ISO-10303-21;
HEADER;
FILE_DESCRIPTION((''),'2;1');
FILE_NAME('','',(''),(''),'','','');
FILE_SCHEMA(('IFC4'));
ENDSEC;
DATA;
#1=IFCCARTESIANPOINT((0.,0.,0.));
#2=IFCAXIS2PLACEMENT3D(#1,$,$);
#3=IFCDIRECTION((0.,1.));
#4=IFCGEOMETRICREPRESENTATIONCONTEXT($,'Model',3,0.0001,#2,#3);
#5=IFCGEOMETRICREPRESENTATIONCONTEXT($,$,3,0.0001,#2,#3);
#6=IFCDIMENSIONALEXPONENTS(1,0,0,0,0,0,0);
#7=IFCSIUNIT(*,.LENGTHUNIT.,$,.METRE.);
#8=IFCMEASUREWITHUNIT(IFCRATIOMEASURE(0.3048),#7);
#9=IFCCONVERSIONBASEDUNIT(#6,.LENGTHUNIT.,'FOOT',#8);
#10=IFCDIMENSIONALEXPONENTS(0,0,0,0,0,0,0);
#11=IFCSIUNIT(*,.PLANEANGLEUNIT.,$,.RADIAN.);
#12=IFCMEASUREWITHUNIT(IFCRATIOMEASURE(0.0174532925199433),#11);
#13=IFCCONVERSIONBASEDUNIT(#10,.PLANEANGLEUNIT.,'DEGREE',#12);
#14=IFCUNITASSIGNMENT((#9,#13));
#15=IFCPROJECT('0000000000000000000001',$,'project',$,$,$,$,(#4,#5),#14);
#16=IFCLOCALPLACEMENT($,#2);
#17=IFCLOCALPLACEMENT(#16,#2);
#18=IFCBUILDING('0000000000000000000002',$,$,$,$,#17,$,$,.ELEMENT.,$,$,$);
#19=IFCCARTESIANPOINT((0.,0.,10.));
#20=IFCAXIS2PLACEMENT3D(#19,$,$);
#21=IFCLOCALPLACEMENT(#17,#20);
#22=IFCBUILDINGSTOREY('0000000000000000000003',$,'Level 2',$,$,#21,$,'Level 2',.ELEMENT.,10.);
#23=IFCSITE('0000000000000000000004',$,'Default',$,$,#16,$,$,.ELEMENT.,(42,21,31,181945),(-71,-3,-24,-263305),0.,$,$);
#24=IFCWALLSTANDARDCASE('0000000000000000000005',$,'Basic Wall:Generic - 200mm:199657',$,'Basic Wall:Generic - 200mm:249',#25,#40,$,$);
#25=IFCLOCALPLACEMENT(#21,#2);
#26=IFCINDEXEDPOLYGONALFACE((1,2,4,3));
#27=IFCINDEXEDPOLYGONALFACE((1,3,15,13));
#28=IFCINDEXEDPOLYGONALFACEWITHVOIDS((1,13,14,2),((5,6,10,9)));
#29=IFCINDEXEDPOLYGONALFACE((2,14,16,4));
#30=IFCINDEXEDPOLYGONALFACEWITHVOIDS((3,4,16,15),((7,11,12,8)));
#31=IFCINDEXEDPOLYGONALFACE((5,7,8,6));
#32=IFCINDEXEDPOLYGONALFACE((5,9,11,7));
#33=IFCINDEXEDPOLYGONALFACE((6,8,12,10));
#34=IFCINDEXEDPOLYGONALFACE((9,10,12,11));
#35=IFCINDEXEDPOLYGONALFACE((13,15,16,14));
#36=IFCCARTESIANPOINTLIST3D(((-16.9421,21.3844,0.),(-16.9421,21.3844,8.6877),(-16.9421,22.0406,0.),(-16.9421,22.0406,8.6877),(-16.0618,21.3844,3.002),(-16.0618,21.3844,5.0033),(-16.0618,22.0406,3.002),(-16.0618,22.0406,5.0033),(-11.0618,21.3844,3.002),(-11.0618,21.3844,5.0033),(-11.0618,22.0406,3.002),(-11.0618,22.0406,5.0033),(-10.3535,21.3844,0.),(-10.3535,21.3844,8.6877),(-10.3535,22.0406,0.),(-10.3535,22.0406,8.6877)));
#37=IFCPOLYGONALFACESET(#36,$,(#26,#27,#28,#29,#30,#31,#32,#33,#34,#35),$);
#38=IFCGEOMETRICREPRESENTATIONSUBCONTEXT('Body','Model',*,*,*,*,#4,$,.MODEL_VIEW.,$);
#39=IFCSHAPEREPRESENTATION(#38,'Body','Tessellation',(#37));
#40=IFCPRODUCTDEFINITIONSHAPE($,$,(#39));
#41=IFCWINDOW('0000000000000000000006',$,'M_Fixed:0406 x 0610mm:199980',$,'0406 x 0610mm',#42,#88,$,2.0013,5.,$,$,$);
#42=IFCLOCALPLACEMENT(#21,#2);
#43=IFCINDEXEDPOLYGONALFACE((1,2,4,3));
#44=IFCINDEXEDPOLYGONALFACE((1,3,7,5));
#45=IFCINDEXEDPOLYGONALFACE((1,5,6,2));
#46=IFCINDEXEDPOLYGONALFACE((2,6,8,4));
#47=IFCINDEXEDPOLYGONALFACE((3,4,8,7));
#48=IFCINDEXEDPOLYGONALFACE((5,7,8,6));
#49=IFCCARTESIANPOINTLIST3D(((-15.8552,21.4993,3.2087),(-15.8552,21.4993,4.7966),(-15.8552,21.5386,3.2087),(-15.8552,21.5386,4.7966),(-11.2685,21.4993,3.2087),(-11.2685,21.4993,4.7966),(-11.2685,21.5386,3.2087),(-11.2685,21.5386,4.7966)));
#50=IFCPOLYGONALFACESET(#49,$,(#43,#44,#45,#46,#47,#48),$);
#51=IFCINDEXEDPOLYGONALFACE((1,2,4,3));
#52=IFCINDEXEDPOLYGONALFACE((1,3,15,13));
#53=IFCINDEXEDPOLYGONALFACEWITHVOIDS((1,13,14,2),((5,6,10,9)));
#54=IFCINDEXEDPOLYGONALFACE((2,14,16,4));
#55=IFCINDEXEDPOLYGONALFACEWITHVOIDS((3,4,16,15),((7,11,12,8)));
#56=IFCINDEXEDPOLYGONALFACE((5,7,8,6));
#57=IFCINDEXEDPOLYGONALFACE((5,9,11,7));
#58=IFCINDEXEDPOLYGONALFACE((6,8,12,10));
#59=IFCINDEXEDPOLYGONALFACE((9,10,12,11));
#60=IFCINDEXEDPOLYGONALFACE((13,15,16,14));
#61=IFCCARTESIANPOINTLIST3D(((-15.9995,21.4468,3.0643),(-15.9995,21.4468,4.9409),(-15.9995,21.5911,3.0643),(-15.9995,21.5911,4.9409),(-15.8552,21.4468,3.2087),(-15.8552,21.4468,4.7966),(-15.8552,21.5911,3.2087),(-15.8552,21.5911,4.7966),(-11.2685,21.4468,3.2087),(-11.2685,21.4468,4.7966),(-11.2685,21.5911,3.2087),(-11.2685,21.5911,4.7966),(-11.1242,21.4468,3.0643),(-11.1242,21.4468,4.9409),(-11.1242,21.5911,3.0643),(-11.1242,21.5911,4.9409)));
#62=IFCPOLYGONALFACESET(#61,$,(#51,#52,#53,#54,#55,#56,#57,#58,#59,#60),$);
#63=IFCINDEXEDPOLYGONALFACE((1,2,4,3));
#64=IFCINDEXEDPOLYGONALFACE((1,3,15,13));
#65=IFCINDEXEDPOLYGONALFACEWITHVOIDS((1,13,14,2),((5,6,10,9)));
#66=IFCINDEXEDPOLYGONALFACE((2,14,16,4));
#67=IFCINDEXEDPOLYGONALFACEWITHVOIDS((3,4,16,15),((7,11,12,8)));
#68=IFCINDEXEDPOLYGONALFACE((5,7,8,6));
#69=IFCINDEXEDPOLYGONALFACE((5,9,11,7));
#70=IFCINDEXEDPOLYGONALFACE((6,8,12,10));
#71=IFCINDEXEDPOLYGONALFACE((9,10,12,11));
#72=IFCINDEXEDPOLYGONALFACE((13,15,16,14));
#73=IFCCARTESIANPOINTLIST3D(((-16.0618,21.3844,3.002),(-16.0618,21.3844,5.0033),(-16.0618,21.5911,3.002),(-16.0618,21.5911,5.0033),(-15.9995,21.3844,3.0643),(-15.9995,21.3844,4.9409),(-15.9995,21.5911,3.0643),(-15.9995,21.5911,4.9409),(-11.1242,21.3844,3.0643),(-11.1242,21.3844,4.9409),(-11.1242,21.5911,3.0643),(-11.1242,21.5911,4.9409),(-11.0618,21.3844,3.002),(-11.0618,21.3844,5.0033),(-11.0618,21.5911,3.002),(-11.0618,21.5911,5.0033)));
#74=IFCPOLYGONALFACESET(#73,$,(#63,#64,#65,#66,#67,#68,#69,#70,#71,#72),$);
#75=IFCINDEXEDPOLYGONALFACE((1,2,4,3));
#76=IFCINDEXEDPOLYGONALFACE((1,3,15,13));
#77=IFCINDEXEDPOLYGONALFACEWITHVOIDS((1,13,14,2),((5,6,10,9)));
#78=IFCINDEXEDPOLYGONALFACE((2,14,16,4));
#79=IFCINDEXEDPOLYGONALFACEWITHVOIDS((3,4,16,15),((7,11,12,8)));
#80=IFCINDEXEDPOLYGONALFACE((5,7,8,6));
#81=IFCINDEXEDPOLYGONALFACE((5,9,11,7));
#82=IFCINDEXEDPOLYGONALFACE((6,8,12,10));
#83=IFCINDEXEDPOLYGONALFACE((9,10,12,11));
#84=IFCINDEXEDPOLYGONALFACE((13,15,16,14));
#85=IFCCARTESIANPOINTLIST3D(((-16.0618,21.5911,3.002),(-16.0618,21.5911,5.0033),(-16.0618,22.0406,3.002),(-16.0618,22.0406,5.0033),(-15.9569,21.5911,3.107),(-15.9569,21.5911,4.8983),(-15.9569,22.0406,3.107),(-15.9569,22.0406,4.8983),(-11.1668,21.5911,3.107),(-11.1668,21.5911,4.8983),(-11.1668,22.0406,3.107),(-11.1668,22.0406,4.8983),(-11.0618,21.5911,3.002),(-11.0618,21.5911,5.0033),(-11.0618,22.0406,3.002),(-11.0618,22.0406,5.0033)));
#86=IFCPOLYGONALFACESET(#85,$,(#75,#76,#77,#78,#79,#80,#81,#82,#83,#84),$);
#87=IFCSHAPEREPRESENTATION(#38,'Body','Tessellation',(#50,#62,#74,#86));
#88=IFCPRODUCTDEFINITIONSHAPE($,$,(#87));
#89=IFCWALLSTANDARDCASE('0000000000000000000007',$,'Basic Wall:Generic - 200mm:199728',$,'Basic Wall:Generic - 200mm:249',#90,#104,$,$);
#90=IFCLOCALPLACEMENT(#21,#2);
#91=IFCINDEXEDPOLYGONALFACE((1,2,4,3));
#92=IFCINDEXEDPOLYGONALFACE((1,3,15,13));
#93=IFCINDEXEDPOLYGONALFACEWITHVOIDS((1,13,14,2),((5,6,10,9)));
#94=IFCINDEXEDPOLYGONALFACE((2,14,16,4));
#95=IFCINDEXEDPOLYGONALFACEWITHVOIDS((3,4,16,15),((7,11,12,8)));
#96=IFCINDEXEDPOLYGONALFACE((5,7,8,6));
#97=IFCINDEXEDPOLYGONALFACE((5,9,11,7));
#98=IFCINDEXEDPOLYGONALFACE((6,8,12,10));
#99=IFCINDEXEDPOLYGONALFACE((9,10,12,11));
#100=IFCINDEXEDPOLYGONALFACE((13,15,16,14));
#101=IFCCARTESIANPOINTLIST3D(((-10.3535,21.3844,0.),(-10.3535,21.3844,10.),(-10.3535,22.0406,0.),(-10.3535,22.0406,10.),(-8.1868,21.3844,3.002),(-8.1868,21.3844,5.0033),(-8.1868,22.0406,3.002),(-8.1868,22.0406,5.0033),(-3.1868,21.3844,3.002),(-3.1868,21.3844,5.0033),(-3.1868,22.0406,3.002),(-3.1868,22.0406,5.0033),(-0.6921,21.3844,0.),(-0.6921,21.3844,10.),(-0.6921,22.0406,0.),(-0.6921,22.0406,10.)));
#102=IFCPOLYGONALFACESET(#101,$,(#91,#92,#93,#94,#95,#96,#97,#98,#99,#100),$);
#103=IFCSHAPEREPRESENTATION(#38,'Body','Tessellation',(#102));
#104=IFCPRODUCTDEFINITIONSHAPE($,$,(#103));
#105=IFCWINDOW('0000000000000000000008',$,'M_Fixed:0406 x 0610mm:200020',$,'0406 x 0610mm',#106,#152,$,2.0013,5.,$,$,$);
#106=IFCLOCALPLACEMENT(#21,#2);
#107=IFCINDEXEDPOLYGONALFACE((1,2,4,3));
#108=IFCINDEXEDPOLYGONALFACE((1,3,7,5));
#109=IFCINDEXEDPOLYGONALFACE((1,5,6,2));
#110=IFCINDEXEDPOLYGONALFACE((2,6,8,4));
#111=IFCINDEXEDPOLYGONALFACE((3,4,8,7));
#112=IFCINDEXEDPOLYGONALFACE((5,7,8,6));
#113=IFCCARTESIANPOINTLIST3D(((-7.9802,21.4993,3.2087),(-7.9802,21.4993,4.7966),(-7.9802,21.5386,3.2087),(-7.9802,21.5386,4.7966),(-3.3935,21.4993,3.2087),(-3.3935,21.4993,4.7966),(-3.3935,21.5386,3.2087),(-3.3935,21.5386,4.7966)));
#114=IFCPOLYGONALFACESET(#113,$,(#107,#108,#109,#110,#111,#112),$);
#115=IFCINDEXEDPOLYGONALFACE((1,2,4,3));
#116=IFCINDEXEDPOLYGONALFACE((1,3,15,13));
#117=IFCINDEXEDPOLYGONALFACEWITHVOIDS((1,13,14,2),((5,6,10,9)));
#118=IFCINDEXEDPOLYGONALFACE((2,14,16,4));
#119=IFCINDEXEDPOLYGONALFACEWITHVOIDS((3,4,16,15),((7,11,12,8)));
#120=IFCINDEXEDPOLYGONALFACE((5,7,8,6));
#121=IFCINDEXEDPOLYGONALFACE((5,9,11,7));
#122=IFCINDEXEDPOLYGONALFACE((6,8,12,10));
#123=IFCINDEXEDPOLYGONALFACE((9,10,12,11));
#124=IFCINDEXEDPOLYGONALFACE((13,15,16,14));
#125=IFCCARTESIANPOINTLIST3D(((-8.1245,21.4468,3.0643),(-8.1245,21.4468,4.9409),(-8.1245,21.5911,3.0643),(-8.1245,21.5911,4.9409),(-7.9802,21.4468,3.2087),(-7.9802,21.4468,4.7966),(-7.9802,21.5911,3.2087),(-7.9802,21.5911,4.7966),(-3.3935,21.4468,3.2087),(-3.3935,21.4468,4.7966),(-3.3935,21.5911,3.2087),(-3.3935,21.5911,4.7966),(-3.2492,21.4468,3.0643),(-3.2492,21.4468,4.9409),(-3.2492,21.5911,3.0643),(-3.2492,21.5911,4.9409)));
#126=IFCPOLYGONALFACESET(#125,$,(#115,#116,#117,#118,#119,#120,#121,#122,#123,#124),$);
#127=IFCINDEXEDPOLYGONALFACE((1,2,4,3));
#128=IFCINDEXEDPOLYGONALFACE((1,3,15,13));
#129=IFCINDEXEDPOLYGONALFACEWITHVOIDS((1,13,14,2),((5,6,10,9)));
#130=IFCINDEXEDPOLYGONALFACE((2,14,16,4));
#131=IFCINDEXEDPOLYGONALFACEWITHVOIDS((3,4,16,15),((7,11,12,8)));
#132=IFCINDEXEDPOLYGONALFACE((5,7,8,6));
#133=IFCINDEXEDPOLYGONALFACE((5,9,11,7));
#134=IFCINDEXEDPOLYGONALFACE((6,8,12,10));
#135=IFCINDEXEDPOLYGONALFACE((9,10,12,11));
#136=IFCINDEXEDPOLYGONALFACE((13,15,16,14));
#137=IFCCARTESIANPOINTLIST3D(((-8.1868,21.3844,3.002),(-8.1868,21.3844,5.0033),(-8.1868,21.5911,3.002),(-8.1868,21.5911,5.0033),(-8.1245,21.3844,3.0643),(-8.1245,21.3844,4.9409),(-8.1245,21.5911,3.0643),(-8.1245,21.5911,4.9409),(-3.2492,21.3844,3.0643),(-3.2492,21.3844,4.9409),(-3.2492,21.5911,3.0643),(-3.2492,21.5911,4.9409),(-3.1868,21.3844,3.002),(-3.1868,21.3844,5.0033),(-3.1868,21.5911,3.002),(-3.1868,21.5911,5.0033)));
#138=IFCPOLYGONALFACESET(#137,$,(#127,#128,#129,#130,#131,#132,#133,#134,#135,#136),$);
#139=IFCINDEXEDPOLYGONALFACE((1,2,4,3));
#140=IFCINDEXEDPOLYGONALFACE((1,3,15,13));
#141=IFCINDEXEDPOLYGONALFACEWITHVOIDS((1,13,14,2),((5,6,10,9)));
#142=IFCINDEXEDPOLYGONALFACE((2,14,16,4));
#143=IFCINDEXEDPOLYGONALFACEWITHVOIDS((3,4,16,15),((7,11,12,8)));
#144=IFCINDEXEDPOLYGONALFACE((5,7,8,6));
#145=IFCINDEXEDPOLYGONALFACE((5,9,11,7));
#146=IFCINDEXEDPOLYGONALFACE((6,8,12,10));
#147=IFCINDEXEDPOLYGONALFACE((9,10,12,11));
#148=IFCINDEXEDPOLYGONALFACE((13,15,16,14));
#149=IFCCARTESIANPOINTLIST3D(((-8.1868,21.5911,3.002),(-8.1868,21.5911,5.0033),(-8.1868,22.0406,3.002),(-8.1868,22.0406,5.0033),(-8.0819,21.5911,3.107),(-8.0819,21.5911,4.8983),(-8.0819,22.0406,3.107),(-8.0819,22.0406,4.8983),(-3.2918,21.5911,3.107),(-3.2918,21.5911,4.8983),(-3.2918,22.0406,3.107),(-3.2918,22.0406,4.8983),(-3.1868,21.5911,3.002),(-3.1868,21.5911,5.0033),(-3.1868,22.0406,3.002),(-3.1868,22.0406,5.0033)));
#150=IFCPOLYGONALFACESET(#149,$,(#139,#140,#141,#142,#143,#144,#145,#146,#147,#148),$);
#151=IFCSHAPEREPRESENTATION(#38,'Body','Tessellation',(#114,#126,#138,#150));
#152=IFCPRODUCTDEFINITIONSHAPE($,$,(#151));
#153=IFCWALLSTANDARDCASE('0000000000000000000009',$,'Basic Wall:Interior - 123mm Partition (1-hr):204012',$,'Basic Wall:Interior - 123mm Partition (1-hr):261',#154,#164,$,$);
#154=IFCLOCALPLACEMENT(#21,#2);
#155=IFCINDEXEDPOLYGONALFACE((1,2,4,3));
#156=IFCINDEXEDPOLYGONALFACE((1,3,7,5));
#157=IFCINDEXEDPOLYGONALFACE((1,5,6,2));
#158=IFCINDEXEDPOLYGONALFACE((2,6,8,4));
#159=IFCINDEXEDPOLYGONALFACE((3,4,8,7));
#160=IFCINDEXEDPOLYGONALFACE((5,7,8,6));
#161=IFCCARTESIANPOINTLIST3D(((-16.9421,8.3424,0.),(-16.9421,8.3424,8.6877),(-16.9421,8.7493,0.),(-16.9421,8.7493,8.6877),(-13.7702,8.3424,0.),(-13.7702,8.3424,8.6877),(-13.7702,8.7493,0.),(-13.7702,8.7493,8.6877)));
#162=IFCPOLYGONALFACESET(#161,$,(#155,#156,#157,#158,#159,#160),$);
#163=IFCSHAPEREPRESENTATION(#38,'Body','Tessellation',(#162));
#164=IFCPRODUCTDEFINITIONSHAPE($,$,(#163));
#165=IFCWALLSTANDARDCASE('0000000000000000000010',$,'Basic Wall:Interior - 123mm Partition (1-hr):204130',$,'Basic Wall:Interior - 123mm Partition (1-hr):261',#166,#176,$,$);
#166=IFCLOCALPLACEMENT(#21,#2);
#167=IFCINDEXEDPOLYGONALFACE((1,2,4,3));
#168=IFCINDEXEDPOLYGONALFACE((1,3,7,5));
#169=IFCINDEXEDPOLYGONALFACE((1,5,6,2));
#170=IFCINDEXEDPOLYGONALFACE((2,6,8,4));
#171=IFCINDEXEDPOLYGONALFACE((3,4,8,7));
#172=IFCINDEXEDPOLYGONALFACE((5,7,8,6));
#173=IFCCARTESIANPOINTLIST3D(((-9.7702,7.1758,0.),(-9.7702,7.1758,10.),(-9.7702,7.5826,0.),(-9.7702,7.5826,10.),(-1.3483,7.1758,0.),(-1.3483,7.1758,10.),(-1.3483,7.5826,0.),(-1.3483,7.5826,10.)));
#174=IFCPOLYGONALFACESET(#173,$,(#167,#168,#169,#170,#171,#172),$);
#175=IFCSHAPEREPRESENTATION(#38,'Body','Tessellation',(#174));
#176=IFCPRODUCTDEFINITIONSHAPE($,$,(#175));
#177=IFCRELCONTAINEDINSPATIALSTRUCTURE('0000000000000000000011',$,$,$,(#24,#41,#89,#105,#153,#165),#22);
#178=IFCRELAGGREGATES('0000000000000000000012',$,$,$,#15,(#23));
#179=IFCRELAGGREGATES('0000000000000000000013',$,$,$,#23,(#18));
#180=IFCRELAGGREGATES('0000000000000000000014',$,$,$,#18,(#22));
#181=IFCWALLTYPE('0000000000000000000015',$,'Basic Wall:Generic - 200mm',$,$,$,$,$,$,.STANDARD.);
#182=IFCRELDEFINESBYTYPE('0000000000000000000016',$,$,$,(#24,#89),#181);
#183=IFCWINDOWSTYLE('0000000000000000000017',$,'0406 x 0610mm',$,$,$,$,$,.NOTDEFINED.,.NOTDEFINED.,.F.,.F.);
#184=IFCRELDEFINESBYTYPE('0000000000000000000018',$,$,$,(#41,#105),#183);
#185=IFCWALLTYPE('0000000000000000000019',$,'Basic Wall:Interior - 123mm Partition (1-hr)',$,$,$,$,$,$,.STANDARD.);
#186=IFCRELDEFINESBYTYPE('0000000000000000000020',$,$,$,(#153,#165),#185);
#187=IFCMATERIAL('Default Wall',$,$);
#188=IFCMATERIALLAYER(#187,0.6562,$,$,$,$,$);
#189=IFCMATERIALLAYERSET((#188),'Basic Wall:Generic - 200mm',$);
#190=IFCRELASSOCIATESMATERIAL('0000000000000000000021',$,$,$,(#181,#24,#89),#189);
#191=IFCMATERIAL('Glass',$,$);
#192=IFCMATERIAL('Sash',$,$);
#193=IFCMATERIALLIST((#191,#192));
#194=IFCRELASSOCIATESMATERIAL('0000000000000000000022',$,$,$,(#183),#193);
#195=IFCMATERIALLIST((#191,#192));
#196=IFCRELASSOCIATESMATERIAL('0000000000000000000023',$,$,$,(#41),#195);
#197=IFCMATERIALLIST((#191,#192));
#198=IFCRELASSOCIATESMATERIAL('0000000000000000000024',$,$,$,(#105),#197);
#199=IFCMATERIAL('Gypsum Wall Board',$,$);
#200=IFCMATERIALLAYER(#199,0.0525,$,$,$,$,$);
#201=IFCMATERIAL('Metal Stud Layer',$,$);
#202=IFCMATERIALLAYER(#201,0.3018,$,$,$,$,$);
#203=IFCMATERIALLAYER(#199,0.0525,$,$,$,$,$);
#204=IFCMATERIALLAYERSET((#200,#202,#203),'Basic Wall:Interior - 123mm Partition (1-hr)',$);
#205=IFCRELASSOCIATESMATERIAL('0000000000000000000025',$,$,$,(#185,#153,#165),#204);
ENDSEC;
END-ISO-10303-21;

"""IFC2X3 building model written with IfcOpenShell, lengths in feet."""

from ifc_helpers import new_model, entity, si_unit, converted_unit, direction, frame, frame_2d, origin, place, context, subcontext, project, spatial, polyline, rectangle, outline, extrude, clip, halfspace, source, transform, mapped, material, material_list, layer, layer_set, layer_usage, type_object, type_shapes, element, fill, save


model = new_model("IFC2X3")

# Units and contexts
model_context = context("Model", 3, precision=0.0001, world=origin(), true_north=direction((0.0, 1.0)))
context_of_model = context(None, 3, precision=0.0001, world=origin(), true_north=direction((0.0, 1.0)))
body_context = subcontext(model_context, "Body", "Model", "MODEL_VIEW")
ifc_project = project(units=[converted_unit("LENGTHUNIT", "FOOT", entity("IfcRatioMeasure", 0.3048), si_unit("LENGTHUNIT", "METRE"), dimensions=[1, 0, 0, 0, 0, 0, 0]), converted_unit("PLANEANGLEUNIT", "DEGREE", entity("IfcRatioMeasure", 0.0174532925199433), si_unit("PLANEANGLEUNIT", "RADIAN"), dimensions=[0, 0, 0, 0, 0, 0, 0])], contexts=[model_context, context_of_model])

# Site, building, storey
site_placement = place(None, origin())
site = spatial("IfcSite", under=ifc_project, at=site_placement, Name="Default", CompositionType="ELEMENT", RefLatitude=(42, 21, 31, 181945), RefLongitude=(-71, -3, -24, -263305), RefElevation=0.0)
building_placement = place(site_placement, origin())
building = spatial("IfcBuilding", under=site, at=building_placement, CompositionType="ELEMENT")
storey_placement = place(building_placement, frame((0.0, 0.0, 10.0)))
storey = spatial("IfcBuildingStorey", under=building, at=storey_placement, Name="Level 2", LongName="Level 2", CompositionType="ELEMENT", Elevation=10.0)

# Shared definitions
ifc_material_1 = material(Name="Default Wall")

# Shared definitions
ifc_material_2 = material(Name="Glass")
ifc_material_3 = material(Name="Sash")

# Shared definitions
ifc_layer_1 = layer(ifc_material_1, 0.6562)
ifc_layer_set_1 = layer_set([ifc_layer_1], Name="Basic Wall:Generic - 200mm")
wall_type_1 = type_object("IfcWallType", Name="Basic Wall:Generic - 200mm", PredefinedType="STANDARD", material=ifc_layer_set_1)

# Walls, openings, windows
ifc_layer_usage_1 = layer_usage(ifc_layer_set_1, "AXIS2", "NEGATIVE", 0.3281)
wall_1_placement = place(storey_placement, frame((-16.9421, 21.7125, 0.0)))
wall_1 = element("IfcWallStandardCase", 1, at=wall_1_placement, inside=storey, type_object=wall_type_1, material=ifc_layer_usage_1, Name="Basic Wall:Generic - 200mm:199657", ObjectType="Basic Wall:Generic - 200mm:249", context=body_context, shape_type="Clipping", body=[
    clip(extrude(rectangle(XDim=6.5886, YDim=0.6562, at=frame_2d((3.2943, 0.0), x_axis=(-1.0, 0.0))), origin(), (0.0, 0.0, 1.0), 8.6877), halfspace(frame((0.0, 0.0, -10.0)), True)),
])
opening_1_placement = place(wall_1_placement, frame((5.8802, 0.3281, 3.002)))
opening_1 = element("IfcOpeningElement", 2, at=opening_1_placement, cuts=wall_1, ObjectType="Opening", context=body_context, shape_type="SweptSolid", body=[
    extrude(rectangle(XDim=2.0013, YDim=5.0, at=frame_2d((1.0007, 2.5), x_axis=(1.0, 0.0))), frame((0.0, 0.0, 0.0), z_axis=(0.0, -1.0, 0.0), x_axis=(0.0, 0.0, 1.0)), (0.0, 0.0, 1.0), 0.6562),
])
ifc_material_list_1 = material_list([ifc_material_2, ifc_material_3])
ifc_material_list_2 = material_list([ifc_material_2, ifc_material_3])
window_style_1 = type_object("IfcWindowStyle", Name="0406 x 0610mm", ConstructionType="NOTDEFINED", OperationType="NOTDEFINED", ParameterTakesPrecedence=False, Sizeable=False, material=ifc_material_list_2)
shared_shape_1 = source(origin(), body_context, "Body", "SweptSolid", [
    extrude(rectangle(XDim=0.0394, YDim=4.5866, at=frame_2d((0.0, 0.0), x_axis=(1.0, 0.0))), frame((2.5, 0.5217, 0.2067), z_axis=(0.0, 0.0, 1.0), x_axis=(0.0, -1.0, 0.0)), (0.0, 0.0, 1.0), 1.5879),
    extrude(outline(polyline([(-2.4377, -0.9383), (2.4377, -0.9383), (2.4377, 0.9383), (-2.4377, 0.9383), (-2.4377, -0.9383)]), holes=[polyline([(-2.2933, -0.794), (-2.2933, 0.794), (2.2933, 0.794), (2.2933, -0.794), (-2.2933, -0.794)])]), frame((2.5, 0.4495, 1.0007), z_axis=(0.0, 1.0, 0.0), x_axis=(1.0, 0.0, 0.0)), (0.0, 0.0, 1.0), 0.1444),
    extrude(outline(polyline([(-2.5, -1.0007), (2.5, -1.0007), (2.5, 1.0007), (-2.5, 1.0007), (-2.5, -1.0007)]), holes=[polyline([(-2.4377, -0.9383), (-2.4377, 0.9383), (2.4377, 0.9383), (2.4377, -0.9383), (-2.4377, -0.9383)])]), frame((2.5, 0.4495, 1.0007), z_axis=(0.0, 1.0, 0.0), x_axis=(1.0, 0.0, 0.0)), (0.0, 0.0, 1.0), 0.2067),
    extrude(outline(polyline([(-2.5, -1.0007), (2.5, -1.0007), (2.5, 1.0007), (-2.5, 1.0007), (-2.5, -1.0007)]), holes=[polyline([(-2.395, -0.8957), (-2.395, 0.8957), (2.395, 0.8957), (2.395, -0.8957), (-2.395, -0.8957)])]), frame((2.5, 0.0, 1.0007), z_axis=(0.0, 1.0, 0.0), x_axis=(1.0, 0.0, 0.0)), (0.0, 0.0, 1.0), 0.4495),
])
type_shapes(window_style_1, [shared_shape_1])
window_1_placement = place(opening_1_placement, frame((0.0, 0.0, 0.0), z_axis=(0.0, 0.0, 1.0), x_axis=(-1.0, 0.0, 0.0)))
window_1 = element("IfcWindow", 3, at=window_1_placement, inside=storey, type_object=window_style_1, material=ifc_material_list_1, Name="M_Fixed:0406 x 0610mm:199980", ObjectType="0406 x 0610mm", OverallHeight=2.0013, OverallWidth=5.0, context=body_context, shape_type="MappedRepresentation", body=[
    mapped(shared_shape_1, transform((0.0, 0.0, 0.0), scale=1.0)),
])
fill(opening_1, window_1)
ifc_layer_usage_2 = layer_usage(ifc_layer_set_1, "AXIS2", "NEGATIVE", 0.3281)
wall_2_placement = place(storey_placement, frame((-10.6816, 21.7125, 0.0)))
wall_2 = element("IfcWallStandardCase", 4, at=wall_2_placement, inside=storey, type_object=wall_type_1, material=ifc_layer_usage_2, Name="Basic Wall:Generic - 200mm:199728", ObjectType="Basic Wall:Generic - 200mm:249", context=body_context, shape_type="Clipping", body=[
    clip(extrude(rectangle(XDim=9.6614, YDim=0.6562, at=frame_2d((5.1588, 0.0), x_axis=(-1.0, 0.0))), origin(), (0.0, 0.0, 1.0), 10.0), halfspace(frame((0.0, 0.0, -10.0)), True)),
])
opening_2_placement = place(wall_2_placement, frame((7.4948, 0.3281, 3.002)))
opening_2 = element("IfcOpeningElement", 5, at=opening_2_placement, cuts=wall_2, ObjectType="Opening", context=body_context, shape_type="SweptSolid", body=[
    extrude(rectangle(XDim=2.0013, YDim=5.0, at=frame_2d((1.0007, 2.5), x_axis=(1.0, 0.0))), frame((0.0, 0.0, 0.0), z_axis=(0.0, -1.0, 0.0), x_axis=(0.0, 0.0, 1.0)), (0.0, 0.0, 1.0), 0.6562),
])
ifc_material_list_3 = material_list([ifc_material_2, ifc_material_3])
window_2_placement = place(opening_2_placement, frame((0.0, 0.0, 0.0), z_axis=(0.0, 0.0, 1.0), x_axis=(-1.0, 0.0, 0.0)))
window_2 = element("IfcWindow", 6, at=window_2_placement, inside=storey, type_object=window_style_1, material=ifc_material_list_3, Name="M_Fixed:0406 x 0610mm:200020", ObjectType="0406 x 0610mm", OverallHeight=2.0013, OverallWidth=5.0, context=body_context, shape_type="MappedRepresentation", body=[
    mapped(shared_shape_1, transform((0.0, 0.0, 0.0), scale=1.0)),
])
fill(opening_2, window_2)

# Walls
ifc_material_4 = material(Name="Gypsum Wall Board")
ifc_layer_2 = layer(ifc_material_4, 0.0525)
ifc_material_5 = material(Name="Metal Stud Layer")
ifc_layer_3 = layer(ifc_material_5, 0.3018)
ifc_layer_4 = layer(ifc_material_4, 0.0525)
ifc_layer_set_2 = layer_set([ifc_layer_2, ifc_layer_3, ifc_layer_4], Name="Basic Wall:Interior - 123mm Partition (1-hr)")
ifc_layer_usage_3 = layer_usage(ifc_layer_set_2, "AXIS2", "NEGATIVE", 0.2034)
wall_type_2 = type_object("IfcWallType", Name="Basic Wall:Interior - 123mm Partition (1-hr)", PredefinedType="STANDARD", material=ifc_layer_set_2)
wall_3_placement = place(storey_placement, frame((-16.9421, 8.5459, 0.0)))
element("IfcWallStandardCase", 7, at=wall_3_placement, inside=storey, type_object=wall_type_2, material=ifc_layer_usage_3, Name="Basic Wall:Interior - 123mm Partition (1-hr):204012", ObjectType="Basic Wall:Interior - 123mm Partition (1-hr):261", context=body_context, shape_type="SweptSolid", body=[
    extrude(rectangle(XDim=3.1719, YDim=0.4068, at=frame_2d((1.586, 0.0), x_axis=(-1.0, 0.0))), origin(), (0.0, 0.0, 1.0), 8.6877),
])
ifc_layer_usage_4 = layer_usage(ifc_layer_set_2, "AXIS2", "NEGATIVE", 0.2034)
wall_4_placement = place(storey_placement, frame((-1.3483, 7.3792, 0.0), z_axis=(0.0, 0.0, 1.0), x_axis=(-1.0, 0.0, 0.0)))
element("IfcWallStandardCase", 8, at=wall_4_placement, inside=storey, type_object=wall_type_2, material=ifc_layer_usage_4, Name="Basic Wall:Interior - 123mm Partition (1-hr):204130", ObjectType="Basic Wall:Interior - 123mm Partition (1-hr):261", context=body_context, shape_type="SweptSolid", body=[
    extrude(rectangle(XDim=8.4219, YDim=0.4068, at=frame_2d((4.211, 0.0), x_axis=(-1.0, 0.0))), origin(), (0.0, 0.0, 1.0), 10.0),
])

save(model, "model.ifc")
